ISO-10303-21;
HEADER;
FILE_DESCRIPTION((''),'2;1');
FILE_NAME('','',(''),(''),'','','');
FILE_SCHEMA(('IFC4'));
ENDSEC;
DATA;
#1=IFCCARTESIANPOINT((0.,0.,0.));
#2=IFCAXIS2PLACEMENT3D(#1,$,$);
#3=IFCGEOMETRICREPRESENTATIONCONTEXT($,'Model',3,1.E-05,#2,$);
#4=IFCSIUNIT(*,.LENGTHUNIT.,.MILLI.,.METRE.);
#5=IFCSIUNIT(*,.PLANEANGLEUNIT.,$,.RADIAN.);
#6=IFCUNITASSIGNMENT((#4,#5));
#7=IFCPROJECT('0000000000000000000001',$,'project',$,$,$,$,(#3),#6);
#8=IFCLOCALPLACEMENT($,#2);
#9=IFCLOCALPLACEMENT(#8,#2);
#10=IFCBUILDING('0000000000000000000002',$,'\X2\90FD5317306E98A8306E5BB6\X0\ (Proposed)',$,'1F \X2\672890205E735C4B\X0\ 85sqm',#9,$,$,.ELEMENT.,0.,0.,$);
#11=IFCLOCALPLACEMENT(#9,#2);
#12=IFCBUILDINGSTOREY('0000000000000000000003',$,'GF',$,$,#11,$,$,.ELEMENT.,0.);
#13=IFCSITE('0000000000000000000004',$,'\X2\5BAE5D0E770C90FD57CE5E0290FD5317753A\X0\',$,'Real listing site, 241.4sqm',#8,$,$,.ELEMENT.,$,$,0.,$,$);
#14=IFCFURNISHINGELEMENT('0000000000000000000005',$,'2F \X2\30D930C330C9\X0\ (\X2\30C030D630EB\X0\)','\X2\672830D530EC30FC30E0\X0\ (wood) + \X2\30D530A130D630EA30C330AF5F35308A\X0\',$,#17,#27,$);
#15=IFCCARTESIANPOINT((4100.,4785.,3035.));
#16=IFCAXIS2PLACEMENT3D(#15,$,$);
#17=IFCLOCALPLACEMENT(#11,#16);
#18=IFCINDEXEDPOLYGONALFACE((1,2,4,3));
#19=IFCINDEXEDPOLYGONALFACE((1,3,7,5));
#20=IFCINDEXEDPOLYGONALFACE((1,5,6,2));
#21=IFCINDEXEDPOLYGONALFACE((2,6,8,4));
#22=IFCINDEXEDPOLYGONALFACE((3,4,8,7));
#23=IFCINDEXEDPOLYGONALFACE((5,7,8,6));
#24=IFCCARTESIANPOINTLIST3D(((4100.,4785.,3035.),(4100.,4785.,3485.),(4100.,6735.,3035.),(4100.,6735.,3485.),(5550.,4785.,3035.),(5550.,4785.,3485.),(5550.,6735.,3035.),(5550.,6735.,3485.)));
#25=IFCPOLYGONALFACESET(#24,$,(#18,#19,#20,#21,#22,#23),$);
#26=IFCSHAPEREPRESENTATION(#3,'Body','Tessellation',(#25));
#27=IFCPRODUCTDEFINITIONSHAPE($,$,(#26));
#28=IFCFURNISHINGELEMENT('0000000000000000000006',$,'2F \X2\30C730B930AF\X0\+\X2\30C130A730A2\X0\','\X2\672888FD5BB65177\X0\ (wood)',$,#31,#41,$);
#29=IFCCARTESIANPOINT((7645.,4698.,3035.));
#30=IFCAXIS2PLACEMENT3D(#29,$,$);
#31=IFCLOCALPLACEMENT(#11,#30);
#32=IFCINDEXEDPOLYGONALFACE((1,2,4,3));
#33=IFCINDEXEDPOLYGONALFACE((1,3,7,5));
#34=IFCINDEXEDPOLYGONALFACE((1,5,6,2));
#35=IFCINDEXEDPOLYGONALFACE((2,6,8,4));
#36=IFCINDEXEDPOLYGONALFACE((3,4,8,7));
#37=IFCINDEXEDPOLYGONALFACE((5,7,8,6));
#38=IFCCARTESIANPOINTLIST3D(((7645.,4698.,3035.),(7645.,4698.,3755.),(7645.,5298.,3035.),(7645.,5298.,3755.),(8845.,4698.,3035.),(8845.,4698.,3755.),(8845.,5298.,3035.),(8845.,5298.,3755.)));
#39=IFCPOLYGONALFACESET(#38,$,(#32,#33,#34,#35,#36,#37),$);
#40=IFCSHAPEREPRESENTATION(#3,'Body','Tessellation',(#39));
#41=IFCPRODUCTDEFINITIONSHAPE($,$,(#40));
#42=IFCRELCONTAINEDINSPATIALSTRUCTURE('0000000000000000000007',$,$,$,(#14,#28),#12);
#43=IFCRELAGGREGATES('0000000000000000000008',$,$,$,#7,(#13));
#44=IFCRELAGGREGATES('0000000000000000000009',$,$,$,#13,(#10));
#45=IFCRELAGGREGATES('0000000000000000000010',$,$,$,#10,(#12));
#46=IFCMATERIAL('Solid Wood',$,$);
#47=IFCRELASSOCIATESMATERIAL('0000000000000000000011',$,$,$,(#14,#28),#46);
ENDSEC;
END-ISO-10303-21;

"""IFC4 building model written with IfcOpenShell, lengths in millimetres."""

from ifc_helpers import new_model, si_unit, frame, frame_2d, origin, place, context, project, spatial, rectangle, extrude, material, element, save


model = new_model("IFC4")

# Units and contexts
model_context = context("Model", 3, precision=1e-05, world=origin())
ifc_project = project(units=[si_unit("LENGTHUNIT", "METRE", prefix="MILLI"), si_unit("PLANEANGLEUNIT", "RADIAN")], contexts=[model_context])

# Site, building, storey
site_placement = place(None, origin())
site = spatial("IfcSite", under=ifc_project, at=site_placement, Name="宮崎県都城市都北町", ObjectType="Real listing site, 241.4sqm", CompositionType="ELEMENT", RefElevation=0.0)
building_placement = place(site_placement, origin())
building = spatial("IfcBuilding", under=site, at=building_placement, Name="都北の風の家 (Proposed)", ObjectType="1F 木造平屋 85sqm", CompositionType="ELEMENT", ElevationOfRefHeight=0.0, ElevationOfTerrain=0.0)
storey_placement = place(building_placement, origin())
storey = spatial("IfcBuildingStorey", under=building, at=storey_placement, Name="GF", CompositionType="ELEMENT", Elevation=0.0)

# Shared definitions
ifc_material_1 = material(Name="Solid Wood")

# Furnishing elements
furnishing_1_placement = place(storey_placement, frame((4100.0, 4785.0, 3035.0)))
element("IfcFurnishingElement", 1, at=furnishing_1_placement, inside=storey, material=ifc_material_1, Name="2F ベッド (ダブル)", Description="木フレーム (wood) + ファブリック張り", context=model_context, shape_type="SweptSolid", body=[
    extrude(rectangle(XDim=1450.0, YDim=1950.0, at=frame_2d((725.0, 975.0))), frame((4100.0, 4785.0, 3035.0)), (0.0, 0.0, 1.0), 450.0),
])
furnishing_2_placement = place(storey_placement, frame((7645.0, 4698.0, 3035.0)))
element("IfcFurnishingElement", 2, at=furnishing_2_placement, inside=storey, material=ifc_material_1, Name="2F デスク+チェア", Description="木製家具 (wood)", context=model_context, shape_type="SweptSolid", body=[
    extrude(rectangle(XDim=1200.0, YDim=600.0, at=frame_2d((600.0, 300.0))), frame((7645.0, 4698.0, 3035.0)), (0.0, 0.0, 1.0), 720.0),
])

save(model, "model.ifc")
